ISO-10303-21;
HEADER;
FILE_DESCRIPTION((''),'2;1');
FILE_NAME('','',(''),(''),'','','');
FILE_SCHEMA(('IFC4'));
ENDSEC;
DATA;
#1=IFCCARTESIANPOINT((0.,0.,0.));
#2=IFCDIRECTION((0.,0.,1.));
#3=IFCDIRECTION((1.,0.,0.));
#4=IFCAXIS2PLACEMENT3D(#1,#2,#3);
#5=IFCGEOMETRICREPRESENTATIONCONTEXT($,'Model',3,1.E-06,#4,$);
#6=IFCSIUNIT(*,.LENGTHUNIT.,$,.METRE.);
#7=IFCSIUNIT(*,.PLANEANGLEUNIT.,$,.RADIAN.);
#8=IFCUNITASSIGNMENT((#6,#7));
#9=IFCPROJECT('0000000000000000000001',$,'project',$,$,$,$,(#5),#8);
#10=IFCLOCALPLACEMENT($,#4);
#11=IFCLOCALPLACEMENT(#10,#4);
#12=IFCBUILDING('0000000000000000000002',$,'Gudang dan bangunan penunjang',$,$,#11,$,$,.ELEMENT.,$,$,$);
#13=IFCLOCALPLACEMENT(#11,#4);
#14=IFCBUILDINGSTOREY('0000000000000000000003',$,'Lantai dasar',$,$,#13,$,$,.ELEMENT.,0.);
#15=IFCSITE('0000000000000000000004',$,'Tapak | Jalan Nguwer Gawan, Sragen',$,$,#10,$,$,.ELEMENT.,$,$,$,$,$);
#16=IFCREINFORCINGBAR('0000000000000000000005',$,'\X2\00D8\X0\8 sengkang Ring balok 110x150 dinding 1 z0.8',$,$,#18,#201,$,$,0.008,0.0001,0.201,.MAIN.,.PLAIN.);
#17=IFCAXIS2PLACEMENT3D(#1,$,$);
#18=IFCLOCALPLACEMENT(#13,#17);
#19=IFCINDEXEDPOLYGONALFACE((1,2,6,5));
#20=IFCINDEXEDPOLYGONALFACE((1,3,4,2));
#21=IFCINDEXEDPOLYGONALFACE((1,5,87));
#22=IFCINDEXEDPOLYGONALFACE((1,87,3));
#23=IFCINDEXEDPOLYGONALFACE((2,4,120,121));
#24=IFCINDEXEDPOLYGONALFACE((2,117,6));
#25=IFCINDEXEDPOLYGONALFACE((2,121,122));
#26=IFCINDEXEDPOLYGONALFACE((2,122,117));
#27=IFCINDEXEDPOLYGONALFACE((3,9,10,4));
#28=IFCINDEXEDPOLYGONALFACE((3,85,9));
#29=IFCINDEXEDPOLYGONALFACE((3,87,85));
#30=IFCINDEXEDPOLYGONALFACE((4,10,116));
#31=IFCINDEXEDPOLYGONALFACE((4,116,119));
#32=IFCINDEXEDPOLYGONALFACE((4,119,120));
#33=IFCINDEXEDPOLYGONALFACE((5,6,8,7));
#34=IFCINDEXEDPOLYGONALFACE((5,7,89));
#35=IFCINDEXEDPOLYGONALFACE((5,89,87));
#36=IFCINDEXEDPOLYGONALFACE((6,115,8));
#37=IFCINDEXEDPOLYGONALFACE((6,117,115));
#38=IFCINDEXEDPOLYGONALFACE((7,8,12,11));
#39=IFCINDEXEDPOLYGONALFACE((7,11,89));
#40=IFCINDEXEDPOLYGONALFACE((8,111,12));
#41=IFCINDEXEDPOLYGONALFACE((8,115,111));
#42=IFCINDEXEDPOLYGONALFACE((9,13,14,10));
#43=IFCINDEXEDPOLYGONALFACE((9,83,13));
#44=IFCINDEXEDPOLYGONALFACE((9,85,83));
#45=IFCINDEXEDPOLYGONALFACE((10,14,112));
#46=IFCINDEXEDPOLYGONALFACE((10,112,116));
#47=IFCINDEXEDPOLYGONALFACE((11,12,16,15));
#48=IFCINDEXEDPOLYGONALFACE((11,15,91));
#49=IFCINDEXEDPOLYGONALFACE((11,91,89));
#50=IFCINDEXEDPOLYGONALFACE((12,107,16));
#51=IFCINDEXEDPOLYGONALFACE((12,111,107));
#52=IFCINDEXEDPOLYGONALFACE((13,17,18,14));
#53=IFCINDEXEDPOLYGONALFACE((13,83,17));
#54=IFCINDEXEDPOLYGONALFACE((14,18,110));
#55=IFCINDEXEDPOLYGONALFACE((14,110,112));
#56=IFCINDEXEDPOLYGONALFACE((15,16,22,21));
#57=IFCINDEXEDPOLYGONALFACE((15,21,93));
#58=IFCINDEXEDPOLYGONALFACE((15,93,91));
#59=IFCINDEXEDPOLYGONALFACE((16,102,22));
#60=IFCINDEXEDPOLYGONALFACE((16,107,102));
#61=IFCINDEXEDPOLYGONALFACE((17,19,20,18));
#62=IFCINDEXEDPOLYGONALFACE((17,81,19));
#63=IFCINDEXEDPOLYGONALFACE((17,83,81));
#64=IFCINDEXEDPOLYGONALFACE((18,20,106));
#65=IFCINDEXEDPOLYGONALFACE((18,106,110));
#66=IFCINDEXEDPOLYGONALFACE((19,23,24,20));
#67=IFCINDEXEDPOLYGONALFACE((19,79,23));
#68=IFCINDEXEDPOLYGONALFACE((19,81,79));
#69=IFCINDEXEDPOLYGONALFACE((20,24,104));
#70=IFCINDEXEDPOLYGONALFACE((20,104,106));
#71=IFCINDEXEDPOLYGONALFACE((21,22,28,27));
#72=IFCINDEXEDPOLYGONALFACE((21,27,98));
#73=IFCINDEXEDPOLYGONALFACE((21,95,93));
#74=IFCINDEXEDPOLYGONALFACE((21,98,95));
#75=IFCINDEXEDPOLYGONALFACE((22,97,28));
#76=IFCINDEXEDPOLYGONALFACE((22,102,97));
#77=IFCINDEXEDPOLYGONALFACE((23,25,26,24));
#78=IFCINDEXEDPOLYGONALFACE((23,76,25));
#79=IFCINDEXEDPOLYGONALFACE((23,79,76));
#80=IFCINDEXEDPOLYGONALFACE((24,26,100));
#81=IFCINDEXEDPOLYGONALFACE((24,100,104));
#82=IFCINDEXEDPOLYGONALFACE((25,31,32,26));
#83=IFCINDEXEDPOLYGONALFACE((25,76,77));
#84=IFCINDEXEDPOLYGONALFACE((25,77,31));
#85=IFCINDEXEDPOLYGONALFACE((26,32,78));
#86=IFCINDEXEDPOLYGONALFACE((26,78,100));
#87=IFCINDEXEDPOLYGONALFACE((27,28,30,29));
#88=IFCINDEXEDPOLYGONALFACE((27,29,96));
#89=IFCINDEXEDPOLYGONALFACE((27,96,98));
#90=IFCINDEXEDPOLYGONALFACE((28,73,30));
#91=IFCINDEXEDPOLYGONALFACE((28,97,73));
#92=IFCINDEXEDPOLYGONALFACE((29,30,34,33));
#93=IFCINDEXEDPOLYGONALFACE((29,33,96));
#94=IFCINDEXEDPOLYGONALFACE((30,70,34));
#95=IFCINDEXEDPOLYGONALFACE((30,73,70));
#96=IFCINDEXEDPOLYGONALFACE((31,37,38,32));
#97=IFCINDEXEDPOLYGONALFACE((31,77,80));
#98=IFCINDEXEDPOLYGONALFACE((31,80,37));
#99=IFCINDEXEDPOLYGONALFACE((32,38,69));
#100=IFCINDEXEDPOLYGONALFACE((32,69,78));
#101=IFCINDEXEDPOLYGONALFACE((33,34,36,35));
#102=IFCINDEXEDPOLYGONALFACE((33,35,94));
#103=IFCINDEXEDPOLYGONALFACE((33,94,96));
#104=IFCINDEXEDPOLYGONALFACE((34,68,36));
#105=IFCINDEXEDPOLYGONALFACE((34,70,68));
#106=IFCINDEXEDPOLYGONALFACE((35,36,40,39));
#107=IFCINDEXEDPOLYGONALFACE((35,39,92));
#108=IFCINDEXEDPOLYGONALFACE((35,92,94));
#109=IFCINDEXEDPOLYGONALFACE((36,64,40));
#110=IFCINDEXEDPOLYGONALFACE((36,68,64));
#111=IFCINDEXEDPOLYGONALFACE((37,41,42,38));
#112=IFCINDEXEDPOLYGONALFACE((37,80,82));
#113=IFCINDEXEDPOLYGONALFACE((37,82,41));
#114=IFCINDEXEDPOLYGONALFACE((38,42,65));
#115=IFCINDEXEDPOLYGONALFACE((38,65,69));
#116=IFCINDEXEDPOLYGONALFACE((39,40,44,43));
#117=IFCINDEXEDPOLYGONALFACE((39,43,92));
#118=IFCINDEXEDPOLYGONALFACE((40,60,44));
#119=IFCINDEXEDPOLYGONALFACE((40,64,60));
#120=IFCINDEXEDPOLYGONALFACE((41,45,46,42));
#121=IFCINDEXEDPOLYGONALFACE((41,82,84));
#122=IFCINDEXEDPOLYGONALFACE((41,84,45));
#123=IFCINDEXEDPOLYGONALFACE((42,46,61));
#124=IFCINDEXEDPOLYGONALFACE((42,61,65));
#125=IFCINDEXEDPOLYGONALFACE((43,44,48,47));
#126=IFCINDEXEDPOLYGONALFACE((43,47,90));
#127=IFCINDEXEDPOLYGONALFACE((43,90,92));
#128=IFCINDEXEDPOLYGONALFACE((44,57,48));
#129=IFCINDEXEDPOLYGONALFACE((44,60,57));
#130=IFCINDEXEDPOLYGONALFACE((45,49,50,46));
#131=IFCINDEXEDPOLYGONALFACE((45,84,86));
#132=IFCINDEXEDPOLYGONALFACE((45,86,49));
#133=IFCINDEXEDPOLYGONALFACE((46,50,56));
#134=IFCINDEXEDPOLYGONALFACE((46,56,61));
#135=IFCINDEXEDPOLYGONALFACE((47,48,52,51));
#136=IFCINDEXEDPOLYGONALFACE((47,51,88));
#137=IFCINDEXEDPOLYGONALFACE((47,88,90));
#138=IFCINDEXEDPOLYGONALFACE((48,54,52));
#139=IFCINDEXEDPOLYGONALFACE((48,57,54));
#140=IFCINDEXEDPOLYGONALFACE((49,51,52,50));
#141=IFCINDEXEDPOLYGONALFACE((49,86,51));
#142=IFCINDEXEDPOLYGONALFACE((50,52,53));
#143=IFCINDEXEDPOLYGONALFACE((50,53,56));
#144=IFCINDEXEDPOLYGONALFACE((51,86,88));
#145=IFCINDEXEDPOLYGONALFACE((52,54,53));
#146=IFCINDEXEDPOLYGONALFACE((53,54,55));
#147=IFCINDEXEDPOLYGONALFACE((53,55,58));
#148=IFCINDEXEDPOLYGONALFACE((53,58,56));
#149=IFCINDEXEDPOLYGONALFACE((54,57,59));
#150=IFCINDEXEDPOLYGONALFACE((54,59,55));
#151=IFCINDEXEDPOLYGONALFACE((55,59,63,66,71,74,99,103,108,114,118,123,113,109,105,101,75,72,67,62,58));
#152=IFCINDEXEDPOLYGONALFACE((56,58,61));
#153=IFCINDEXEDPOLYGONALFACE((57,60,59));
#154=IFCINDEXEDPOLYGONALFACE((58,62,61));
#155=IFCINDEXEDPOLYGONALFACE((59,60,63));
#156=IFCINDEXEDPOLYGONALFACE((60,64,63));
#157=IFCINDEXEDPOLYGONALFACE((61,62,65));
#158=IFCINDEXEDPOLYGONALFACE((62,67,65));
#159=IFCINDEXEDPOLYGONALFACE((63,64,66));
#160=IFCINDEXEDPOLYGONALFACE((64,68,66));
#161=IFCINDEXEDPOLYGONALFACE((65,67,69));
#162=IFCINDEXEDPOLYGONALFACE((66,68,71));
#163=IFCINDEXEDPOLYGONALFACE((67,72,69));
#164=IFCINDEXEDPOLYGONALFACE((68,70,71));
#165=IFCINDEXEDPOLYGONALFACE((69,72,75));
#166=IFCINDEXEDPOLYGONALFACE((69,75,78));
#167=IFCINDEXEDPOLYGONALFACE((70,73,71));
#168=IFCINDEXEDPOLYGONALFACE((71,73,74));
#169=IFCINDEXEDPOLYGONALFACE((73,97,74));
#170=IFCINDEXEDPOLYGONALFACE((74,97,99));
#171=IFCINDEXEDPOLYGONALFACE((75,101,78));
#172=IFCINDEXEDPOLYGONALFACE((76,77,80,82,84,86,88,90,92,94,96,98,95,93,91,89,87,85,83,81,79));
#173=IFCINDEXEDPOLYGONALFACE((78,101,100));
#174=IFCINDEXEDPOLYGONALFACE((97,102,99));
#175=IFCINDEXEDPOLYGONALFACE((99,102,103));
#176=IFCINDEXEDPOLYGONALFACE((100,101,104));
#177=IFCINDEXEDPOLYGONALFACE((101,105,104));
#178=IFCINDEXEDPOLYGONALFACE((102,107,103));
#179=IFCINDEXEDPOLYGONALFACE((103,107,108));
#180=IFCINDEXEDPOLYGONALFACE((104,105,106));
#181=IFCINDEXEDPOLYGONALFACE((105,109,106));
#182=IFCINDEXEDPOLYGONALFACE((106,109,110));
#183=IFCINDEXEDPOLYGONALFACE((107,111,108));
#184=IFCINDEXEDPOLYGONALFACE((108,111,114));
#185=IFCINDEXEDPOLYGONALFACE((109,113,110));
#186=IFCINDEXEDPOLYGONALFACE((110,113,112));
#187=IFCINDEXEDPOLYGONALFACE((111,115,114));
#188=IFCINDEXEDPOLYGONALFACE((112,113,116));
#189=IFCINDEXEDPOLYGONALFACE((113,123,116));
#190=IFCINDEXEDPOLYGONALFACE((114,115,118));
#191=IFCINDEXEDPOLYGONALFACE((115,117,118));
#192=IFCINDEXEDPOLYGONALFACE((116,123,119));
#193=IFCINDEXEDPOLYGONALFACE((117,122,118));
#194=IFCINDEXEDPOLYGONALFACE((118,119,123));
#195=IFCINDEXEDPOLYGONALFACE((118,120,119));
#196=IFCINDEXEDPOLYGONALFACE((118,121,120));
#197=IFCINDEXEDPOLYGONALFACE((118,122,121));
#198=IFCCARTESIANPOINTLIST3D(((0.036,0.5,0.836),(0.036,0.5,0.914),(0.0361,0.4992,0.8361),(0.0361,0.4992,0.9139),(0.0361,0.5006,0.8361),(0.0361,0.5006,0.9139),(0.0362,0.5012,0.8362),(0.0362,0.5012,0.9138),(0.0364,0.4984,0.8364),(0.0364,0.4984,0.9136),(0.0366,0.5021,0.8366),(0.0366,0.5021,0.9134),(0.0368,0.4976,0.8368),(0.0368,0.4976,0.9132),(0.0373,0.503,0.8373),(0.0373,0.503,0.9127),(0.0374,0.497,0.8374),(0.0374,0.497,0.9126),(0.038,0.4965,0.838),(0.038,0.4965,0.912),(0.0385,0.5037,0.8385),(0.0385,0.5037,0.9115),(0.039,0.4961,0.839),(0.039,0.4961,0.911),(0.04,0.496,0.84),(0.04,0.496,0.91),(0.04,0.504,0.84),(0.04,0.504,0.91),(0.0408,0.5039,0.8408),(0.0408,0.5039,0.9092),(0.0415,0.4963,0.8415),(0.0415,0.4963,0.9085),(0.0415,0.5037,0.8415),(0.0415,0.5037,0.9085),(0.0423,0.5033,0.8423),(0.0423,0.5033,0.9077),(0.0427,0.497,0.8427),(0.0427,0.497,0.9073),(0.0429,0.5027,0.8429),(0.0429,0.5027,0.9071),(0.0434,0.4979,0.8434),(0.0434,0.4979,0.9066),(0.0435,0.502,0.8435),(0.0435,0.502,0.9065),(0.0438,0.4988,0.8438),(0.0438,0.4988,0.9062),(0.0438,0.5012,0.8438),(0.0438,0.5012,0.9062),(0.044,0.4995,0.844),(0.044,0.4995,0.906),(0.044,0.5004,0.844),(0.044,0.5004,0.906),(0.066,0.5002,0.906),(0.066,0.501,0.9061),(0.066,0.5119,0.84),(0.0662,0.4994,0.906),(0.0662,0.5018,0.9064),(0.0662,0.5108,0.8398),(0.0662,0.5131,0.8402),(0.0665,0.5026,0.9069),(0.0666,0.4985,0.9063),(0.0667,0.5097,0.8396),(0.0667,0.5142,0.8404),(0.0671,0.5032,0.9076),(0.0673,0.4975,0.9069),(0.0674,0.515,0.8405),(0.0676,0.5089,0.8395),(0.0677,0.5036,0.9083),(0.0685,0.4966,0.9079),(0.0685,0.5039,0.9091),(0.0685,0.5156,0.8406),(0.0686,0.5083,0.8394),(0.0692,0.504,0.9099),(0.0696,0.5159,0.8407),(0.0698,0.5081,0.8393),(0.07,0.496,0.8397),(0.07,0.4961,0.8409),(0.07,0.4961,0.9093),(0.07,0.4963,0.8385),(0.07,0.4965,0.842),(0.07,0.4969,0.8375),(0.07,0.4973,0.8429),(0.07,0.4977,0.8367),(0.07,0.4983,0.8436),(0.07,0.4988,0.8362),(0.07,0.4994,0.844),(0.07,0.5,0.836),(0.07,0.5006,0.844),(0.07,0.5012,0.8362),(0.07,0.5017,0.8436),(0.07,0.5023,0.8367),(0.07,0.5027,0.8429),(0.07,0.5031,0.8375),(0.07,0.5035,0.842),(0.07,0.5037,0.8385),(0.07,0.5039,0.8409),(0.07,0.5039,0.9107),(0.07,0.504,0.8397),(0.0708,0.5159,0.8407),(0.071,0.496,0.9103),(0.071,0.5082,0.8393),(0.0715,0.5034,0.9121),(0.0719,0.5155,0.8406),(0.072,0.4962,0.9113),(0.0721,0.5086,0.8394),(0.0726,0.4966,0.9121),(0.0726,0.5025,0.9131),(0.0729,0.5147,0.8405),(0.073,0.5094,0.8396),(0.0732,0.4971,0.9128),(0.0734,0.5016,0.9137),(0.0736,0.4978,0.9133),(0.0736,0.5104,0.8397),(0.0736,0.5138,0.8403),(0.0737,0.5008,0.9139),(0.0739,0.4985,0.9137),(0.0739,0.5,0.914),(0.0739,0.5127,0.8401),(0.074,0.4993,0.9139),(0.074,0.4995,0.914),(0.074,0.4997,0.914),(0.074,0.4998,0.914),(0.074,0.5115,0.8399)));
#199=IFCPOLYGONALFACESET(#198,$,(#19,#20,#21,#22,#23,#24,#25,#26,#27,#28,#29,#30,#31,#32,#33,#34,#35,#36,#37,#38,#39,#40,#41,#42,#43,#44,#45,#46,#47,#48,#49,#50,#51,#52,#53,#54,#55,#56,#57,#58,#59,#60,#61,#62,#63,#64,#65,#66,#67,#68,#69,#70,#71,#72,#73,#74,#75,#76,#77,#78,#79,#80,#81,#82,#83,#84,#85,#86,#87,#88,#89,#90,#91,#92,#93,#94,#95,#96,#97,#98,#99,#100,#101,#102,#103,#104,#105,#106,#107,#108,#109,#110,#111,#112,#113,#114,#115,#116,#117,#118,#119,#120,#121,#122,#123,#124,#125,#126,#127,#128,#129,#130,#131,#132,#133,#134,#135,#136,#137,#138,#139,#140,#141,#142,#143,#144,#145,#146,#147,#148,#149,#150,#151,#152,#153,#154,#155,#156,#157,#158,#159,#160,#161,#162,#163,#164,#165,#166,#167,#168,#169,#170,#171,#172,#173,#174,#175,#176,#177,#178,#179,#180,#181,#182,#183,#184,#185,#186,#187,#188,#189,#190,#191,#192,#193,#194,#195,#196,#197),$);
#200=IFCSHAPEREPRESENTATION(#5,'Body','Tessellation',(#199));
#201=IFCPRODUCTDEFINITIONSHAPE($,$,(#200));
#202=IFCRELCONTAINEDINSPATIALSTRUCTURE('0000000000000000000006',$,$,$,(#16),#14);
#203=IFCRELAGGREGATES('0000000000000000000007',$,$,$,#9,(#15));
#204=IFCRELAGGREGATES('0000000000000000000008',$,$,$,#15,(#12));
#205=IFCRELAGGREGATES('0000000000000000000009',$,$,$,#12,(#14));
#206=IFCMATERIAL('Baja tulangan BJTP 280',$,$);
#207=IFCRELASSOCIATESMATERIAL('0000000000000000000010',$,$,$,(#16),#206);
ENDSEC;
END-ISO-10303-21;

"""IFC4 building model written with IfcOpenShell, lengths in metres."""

from ifc_helpers import new_model, entity, si_unit, origin_with_axes, place, context, project, spatial, material, element, save


model = new_model("IFC4")

# Units and contexts
model_context = context("Model", 3, precision=1e-06, world=origin_with_axes())
ifc_project = project(units=[si_unit("LENGTHUNIT", "METRE"), si_unit("PLANEANGLEUNIT", "RADIAN")], contexts=[model_context])

# Site, building, storey
site_placement = place(None, origin_with_axes())
site = spatial("IfcSite", under=ifc_project, at=site_placement, Name="Tapak | Jalan Nguwer Gawan, Sragen", CompositionType="ELEMENT")
building_placement = place(site_placement, origin_with_axes())
building = spatial("IfcBuilding", under=site, at=building_placement, Name="Gudang dan bangunan penunjang", CompositionType="ELEMENT")
storey_placement = place(building_placement, origin_with_axes())
storey = spatial("IfcBuildingStorey", under=building, at=storey_placement, Name="Lantai dasar", CompositionType="ELEMENT", Elevation=0.0)

# Shared definitions
placement = place(None, origin_with_axes())

# Reinforcing bar
ifc_material_1 = material(Name="Baja tulangan BJTP 280")
element("IfcReinforcingBar", 1, at=placement, inside=storey, material=ifc_material_1, Name="Ø8 sengkang Ring balok 110x150 dinding 1 z0.8", BarLength=0.201, BarSurface="PLAIN", CrossSectionArea=0.0001, NominalDiameter=0.008, PredefinedType="MAIN", context=model_context, shape_type="AdvancedSweptSolid", body=[
    entity("IfcSweptDiskSolid", entity("IfcPolyline", [entity("IfcCartesianPoint", [0.07, 0.5, 0.84]), entity("IfcCartesianPoint", [0.04, 0.5, 0.84]), entity("IfcCartesianPoint", [0.04, 0.5, 0.91]), entity("IfcCartesianPoint", [0.07, 0.5, 0.91]), entity("IfcCartesianPoint", [0.07, 0.512, 0.84])]), 0.004),
])

save(model, "model.ifc")
